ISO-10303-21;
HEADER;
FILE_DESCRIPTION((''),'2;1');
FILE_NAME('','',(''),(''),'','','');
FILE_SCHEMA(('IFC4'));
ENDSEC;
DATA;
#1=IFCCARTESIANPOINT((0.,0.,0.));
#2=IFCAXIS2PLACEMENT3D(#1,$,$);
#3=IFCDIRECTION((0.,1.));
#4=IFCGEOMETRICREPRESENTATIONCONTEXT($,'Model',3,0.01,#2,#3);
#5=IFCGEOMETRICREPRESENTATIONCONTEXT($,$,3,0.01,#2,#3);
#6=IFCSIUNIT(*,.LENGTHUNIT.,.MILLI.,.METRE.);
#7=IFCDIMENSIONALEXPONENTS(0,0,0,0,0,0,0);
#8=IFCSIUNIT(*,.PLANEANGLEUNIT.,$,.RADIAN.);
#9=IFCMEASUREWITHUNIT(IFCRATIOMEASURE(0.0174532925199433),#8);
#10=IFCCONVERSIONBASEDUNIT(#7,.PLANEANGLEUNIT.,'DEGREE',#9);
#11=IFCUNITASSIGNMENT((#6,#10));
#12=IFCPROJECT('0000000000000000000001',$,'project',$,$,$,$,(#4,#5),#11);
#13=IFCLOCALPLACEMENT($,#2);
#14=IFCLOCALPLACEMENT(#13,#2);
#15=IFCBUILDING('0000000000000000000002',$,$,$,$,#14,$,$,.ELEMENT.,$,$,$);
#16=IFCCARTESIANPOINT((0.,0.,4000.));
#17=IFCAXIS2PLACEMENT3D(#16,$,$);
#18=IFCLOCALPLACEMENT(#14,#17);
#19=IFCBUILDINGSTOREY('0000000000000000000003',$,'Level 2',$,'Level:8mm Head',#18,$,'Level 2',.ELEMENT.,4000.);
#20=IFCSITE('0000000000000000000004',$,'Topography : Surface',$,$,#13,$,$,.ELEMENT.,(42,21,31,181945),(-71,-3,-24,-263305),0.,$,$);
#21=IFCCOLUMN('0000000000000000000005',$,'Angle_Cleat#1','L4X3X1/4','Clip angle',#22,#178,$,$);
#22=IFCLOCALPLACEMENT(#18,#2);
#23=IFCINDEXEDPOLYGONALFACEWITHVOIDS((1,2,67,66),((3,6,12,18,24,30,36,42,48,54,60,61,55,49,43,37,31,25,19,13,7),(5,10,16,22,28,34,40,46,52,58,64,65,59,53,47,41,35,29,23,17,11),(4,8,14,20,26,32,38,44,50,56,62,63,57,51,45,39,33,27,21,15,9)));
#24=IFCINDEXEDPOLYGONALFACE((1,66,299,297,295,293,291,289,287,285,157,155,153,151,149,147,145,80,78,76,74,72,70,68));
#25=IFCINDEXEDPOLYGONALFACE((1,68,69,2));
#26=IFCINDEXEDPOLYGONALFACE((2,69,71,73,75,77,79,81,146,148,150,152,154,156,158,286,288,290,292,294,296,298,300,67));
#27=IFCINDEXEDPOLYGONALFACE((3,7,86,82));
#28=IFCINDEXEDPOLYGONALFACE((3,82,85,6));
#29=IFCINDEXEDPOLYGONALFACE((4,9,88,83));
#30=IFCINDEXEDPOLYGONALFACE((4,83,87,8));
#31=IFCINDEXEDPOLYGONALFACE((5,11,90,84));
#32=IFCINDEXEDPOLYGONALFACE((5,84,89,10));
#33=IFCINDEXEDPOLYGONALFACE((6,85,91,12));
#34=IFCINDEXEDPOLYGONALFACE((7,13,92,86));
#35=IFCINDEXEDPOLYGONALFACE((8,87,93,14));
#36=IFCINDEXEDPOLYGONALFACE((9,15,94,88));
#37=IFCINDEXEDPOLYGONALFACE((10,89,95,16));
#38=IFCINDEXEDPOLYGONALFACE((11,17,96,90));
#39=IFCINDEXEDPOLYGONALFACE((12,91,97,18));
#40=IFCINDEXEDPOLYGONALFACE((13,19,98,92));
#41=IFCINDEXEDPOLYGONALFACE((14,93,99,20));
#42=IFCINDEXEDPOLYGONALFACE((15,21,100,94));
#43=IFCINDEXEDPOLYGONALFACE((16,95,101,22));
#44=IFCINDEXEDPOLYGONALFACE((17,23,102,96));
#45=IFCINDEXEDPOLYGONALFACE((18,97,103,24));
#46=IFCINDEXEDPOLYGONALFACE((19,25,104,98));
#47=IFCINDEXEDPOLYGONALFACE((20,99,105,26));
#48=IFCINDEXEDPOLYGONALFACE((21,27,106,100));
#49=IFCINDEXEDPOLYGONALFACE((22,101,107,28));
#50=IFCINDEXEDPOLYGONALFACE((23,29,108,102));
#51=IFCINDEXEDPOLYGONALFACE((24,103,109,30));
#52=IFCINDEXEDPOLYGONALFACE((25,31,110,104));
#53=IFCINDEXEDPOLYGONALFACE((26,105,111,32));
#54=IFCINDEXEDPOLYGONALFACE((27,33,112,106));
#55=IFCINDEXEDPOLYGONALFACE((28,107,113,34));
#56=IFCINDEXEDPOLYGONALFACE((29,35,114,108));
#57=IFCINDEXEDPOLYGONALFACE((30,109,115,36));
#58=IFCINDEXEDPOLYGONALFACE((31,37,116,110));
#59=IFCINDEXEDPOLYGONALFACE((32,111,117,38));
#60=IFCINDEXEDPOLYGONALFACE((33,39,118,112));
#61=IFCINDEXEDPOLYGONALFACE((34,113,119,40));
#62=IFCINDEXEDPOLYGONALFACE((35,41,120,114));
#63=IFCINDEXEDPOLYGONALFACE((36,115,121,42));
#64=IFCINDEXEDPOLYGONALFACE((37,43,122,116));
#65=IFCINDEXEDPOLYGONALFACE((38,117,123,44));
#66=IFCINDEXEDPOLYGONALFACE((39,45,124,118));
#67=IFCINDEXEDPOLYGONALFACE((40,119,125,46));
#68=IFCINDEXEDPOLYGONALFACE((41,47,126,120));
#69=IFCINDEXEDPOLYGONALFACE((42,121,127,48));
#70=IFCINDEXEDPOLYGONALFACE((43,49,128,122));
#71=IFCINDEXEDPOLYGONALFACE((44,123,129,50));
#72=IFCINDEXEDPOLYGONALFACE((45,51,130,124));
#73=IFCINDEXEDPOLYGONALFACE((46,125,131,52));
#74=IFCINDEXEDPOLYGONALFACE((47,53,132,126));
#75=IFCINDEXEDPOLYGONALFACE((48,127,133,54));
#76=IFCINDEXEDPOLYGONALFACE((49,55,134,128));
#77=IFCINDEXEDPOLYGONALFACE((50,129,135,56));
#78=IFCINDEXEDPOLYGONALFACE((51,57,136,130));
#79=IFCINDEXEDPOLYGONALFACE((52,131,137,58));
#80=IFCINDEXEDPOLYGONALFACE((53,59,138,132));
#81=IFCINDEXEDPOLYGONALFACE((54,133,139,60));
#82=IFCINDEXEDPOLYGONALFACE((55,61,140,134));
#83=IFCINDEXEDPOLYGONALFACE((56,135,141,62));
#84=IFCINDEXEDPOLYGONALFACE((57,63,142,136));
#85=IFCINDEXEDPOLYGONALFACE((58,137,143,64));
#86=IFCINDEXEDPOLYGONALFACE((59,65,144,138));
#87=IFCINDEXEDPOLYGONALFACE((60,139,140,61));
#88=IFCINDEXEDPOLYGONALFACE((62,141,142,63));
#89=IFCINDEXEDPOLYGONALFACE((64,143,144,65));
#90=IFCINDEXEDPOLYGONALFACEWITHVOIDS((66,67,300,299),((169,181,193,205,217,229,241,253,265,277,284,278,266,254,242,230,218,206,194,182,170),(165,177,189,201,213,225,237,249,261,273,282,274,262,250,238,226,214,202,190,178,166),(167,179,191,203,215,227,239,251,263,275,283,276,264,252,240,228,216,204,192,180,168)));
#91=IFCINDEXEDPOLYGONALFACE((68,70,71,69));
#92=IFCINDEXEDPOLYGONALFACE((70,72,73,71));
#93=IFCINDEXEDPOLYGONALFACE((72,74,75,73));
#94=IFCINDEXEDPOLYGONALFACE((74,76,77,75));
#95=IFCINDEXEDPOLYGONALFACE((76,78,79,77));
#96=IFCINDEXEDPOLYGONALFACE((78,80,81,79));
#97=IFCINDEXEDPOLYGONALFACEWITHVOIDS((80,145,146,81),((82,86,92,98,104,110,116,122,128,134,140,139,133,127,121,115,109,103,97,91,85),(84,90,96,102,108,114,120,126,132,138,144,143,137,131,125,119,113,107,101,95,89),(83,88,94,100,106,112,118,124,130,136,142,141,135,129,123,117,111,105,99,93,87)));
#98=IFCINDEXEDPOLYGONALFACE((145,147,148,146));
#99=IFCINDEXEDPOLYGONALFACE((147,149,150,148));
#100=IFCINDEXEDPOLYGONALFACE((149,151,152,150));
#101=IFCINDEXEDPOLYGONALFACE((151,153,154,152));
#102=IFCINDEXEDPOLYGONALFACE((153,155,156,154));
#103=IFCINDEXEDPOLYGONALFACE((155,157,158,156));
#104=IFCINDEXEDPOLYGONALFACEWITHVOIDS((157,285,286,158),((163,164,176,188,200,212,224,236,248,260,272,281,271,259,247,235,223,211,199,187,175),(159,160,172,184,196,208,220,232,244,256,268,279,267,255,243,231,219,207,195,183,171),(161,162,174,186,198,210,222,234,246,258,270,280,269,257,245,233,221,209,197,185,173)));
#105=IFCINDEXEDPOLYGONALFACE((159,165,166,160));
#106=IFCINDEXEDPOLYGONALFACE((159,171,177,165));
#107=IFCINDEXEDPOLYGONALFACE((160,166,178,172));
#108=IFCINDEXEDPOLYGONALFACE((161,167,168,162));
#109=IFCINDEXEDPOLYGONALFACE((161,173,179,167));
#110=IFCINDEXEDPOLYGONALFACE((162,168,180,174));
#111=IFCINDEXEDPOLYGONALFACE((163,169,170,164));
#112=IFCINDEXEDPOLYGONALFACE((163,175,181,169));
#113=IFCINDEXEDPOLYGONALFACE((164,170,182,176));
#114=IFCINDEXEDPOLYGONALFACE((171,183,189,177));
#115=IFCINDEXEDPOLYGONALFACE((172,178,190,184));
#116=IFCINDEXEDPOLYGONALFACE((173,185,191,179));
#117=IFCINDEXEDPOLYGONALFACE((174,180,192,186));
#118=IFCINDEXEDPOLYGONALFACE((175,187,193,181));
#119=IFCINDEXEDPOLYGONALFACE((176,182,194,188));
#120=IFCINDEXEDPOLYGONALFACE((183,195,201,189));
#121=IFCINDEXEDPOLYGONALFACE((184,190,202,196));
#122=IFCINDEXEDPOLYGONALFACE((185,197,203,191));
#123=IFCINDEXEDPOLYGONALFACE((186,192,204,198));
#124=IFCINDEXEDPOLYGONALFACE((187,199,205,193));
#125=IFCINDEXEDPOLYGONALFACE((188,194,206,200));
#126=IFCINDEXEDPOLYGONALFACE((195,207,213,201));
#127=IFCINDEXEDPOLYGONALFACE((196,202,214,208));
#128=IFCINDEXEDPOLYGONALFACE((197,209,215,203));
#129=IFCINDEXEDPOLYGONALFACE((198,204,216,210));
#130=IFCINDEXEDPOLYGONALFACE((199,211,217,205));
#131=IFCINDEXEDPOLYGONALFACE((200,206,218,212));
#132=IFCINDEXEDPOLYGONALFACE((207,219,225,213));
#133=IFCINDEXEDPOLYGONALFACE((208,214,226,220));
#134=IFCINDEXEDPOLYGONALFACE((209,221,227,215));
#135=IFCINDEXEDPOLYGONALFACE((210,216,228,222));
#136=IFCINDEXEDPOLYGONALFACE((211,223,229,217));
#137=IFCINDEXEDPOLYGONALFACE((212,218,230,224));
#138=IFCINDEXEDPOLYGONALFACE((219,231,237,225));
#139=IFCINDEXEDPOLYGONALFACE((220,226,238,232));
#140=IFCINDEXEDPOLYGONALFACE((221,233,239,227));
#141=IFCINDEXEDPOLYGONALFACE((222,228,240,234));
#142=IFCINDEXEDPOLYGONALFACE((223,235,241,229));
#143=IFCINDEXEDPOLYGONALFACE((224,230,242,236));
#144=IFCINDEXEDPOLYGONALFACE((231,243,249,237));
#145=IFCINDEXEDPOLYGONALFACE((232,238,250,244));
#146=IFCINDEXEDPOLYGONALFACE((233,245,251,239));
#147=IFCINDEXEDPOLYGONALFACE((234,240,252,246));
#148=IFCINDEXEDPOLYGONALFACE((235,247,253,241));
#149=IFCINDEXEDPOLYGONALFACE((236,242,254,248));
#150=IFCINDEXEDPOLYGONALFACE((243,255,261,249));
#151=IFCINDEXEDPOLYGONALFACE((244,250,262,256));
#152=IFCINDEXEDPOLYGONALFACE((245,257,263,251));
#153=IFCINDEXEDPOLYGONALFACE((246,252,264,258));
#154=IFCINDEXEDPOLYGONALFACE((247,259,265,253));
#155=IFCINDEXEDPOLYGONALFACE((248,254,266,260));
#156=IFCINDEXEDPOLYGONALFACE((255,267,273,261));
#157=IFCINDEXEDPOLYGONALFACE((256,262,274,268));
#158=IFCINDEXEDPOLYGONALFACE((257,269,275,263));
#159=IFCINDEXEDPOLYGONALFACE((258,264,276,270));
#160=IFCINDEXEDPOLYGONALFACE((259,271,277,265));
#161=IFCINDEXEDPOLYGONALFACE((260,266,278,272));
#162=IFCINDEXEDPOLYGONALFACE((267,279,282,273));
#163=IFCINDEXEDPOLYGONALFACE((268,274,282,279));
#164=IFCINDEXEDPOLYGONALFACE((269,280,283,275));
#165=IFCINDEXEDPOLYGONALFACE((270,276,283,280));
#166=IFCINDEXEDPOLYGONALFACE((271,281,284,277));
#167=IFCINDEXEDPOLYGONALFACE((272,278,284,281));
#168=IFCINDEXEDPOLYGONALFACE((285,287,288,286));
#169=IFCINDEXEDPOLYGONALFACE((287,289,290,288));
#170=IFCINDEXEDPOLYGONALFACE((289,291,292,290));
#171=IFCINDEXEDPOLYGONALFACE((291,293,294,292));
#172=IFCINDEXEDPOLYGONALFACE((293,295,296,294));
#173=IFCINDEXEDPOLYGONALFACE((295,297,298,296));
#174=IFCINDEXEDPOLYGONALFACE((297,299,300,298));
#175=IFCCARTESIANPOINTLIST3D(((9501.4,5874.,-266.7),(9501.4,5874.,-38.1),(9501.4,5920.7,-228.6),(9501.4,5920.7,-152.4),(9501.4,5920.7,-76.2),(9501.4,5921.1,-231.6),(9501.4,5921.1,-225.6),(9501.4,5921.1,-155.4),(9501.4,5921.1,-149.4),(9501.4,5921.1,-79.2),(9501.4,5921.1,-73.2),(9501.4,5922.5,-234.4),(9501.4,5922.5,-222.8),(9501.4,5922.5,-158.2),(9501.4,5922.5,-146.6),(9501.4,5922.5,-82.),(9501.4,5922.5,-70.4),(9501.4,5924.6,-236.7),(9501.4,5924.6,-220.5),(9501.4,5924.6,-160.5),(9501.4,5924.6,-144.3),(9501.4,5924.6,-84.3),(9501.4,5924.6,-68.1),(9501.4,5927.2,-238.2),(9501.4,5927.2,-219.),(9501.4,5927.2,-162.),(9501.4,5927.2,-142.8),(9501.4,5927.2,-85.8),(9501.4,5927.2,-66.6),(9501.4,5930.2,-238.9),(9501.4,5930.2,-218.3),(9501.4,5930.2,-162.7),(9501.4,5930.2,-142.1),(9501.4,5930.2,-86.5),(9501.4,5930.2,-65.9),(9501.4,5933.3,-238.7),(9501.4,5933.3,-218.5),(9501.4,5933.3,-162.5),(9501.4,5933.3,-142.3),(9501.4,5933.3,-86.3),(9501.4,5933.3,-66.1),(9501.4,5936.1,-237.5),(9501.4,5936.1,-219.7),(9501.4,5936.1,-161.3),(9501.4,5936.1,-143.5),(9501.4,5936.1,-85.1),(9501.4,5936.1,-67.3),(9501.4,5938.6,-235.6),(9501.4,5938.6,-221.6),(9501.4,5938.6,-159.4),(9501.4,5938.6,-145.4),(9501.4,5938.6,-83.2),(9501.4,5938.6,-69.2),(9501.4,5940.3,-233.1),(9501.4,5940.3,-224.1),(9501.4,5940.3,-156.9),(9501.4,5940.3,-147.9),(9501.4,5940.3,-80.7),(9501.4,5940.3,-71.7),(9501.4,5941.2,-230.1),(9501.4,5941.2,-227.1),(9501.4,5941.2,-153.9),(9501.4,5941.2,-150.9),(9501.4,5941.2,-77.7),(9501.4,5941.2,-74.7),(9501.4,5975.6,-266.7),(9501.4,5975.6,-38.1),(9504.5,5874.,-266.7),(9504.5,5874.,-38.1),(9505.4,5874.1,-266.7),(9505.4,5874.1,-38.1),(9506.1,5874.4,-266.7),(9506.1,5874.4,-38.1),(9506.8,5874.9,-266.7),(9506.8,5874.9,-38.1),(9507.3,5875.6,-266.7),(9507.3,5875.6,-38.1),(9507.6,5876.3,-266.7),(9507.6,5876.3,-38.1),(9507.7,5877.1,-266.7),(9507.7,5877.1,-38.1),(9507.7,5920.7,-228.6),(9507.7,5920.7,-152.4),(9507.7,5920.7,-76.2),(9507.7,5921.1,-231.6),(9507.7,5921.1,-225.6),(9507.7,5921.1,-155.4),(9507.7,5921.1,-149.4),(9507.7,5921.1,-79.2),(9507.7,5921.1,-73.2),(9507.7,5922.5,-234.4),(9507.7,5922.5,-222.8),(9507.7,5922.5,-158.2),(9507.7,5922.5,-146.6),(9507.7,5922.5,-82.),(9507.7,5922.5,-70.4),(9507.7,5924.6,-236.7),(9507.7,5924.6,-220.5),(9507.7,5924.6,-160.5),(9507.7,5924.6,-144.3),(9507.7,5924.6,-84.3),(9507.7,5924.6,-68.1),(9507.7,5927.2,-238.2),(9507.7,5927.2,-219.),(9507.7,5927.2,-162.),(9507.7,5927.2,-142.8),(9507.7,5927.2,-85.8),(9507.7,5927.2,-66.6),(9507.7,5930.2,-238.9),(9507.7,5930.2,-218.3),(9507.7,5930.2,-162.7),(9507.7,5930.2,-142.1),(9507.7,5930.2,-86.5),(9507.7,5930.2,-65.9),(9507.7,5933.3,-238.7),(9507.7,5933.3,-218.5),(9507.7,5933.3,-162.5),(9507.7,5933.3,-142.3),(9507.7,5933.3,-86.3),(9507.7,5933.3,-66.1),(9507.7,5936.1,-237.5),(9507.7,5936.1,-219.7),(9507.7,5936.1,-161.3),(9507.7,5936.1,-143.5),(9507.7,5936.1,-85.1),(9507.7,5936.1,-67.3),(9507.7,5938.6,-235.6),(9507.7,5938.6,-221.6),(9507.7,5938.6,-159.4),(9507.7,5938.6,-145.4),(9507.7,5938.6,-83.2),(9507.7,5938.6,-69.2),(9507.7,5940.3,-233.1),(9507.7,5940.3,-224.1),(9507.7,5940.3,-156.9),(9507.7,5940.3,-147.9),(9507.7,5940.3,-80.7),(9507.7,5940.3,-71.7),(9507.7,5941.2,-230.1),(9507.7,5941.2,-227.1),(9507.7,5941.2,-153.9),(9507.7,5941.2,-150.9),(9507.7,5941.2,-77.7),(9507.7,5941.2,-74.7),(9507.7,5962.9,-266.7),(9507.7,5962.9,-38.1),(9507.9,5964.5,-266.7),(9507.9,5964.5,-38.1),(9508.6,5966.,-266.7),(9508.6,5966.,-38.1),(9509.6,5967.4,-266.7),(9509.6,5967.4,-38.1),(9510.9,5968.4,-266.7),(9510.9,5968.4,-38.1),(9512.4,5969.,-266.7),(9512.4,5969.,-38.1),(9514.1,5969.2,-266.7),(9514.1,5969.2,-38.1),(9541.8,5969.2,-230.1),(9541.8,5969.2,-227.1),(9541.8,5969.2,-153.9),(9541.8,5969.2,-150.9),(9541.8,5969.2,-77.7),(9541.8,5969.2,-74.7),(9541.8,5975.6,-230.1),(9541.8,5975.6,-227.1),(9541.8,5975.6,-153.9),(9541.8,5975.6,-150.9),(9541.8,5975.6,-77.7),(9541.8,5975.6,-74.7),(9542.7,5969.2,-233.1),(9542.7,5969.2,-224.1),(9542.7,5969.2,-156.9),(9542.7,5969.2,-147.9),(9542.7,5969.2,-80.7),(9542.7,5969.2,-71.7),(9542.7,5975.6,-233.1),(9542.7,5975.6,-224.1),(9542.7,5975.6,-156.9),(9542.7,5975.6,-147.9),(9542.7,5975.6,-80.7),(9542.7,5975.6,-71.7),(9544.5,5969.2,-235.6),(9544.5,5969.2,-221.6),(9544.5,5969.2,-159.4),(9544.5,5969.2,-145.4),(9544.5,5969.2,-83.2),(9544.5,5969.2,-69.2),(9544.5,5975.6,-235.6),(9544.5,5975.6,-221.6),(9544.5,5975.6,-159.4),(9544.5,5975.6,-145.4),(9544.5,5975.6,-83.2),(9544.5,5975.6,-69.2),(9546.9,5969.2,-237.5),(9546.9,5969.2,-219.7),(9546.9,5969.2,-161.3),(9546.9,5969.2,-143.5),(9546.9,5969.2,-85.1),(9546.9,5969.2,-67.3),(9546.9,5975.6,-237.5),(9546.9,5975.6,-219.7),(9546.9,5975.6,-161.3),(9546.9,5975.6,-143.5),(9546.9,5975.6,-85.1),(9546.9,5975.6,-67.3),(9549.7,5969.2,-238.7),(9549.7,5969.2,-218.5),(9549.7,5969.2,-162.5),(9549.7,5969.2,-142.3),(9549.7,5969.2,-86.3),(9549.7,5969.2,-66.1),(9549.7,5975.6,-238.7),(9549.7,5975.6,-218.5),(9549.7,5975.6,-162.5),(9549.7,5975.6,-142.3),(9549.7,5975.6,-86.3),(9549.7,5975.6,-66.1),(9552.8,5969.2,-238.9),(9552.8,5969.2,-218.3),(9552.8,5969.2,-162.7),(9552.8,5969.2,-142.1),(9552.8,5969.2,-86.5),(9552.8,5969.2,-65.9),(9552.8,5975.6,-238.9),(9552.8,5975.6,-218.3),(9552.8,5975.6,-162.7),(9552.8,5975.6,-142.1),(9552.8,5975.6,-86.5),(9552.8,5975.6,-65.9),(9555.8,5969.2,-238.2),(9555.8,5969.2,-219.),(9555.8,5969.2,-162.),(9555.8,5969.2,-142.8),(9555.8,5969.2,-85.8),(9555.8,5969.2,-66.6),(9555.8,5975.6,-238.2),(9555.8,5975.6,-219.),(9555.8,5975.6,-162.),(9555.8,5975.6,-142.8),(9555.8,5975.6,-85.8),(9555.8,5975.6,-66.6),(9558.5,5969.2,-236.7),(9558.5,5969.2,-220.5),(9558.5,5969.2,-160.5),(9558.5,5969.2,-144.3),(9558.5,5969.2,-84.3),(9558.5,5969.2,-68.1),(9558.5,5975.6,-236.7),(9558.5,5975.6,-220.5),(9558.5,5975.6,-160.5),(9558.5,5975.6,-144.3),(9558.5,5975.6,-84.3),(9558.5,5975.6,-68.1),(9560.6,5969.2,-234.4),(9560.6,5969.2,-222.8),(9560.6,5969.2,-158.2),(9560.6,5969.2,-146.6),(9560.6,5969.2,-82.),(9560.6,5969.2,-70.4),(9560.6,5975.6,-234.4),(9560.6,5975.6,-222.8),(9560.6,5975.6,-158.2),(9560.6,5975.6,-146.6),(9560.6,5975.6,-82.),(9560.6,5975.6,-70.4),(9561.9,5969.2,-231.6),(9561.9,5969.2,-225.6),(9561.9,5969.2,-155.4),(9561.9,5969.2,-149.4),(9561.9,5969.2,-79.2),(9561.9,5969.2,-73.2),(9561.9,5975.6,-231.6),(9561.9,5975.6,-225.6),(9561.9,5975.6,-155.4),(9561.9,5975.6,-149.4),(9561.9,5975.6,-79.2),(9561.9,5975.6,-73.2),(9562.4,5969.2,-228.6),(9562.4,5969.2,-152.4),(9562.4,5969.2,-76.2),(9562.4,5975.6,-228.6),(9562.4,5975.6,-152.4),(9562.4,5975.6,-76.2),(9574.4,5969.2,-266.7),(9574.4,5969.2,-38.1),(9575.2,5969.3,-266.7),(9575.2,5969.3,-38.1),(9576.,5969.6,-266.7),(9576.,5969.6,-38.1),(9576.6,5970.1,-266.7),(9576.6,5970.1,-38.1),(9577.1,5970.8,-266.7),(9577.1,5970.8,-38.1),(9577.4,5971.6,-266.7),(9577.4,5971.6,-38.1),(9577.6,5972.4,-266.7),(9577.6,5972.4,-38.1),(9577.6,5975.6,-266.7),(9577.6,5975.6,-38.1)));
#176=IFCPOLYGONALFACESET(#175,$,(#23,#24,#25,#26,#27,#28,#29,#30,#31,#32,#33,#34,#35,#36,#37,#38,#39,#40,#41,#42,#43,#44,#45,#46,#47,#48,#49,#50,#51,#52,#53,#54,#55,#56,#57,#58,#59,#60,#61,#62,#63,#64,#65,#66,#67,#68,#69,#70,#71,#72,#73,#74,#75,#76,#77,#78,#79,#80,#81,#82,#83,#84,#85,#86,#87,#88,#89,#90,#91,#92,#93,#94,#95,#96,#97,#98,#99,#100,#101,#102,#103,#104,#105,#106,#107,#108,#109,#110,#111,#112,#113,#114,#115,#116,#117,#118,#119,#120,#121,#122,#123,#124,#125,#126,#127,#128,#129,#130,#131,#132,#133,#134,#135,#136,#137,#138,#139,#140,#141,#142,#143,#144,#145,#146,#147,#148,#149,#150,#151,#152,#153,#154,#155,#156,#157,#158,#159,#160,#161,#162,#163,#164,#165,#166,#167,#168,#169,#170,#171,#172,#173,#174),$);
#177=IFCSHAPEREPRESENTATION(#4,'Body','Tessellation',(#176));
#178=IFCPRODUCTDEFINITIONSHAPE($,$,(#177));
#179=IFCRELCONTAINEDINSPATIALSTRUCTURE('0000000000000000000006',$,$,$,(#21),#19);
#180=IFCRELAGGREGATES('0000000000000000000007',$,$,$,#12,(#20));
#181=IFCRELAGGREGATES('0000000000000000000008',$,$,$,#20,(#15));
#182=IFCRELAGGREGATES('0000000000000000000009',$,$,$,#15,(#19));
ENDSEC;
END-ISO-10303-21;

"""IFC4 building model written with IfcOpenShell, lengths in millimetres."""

from ifc_helpers import new_model, entity, si_unit, converted_unit, direction, frame, frame_2d, origin, origin_2d_with_axis, place, context, project, spatial, circle, l_section, extrude, element, save


model = new_model("IFC4")

# Units and contexts
model_context = context("Model", 3, precision=0.01, world=origin(), true_north=direction((0.0, 1.0)))
context_of_model = context(None, 3, precision=0.01, world=origin(), true_north=direction((0.0, 1.0)))
ifc_project = project(units=[si_unit("LENGTHUNIT", "METRE", prefix="MILLI"), converted_unit("PLANEANGLEUNIT", "DEGREE", entity("IfcRatioMeasure", 0.0174532925199433), si_unit("PLANEANGLEUNIT", "RADIAN"), dimensions=[0, 0, 0, 0, 0, 0, 0])], contexts=[model_context, context_of_model])

# Site, building, storey
site_placement = place(None, origin())
site = spatial("IfcSite", under=ifc_project, at=site_placement, Name="Topography : Surface", CompositionType="ELEMENT", RefLatitude=(42, 21, 31, 181945), RefLongitude=(-71, -3, -24, -263305), RefElevation=0.0)
building_placement = place(site_placement, origin())
building = spatial("IfcBuilding", under=site, at=building_placement, CompositionType="ELEMENT")
storey_placement = place(building_placement, frame((0.0, 0.0, 4000.0)))
storey = spatial("IfcBuildingStorey", under=building, at=storey_placement, Name="Level 2", ObjectType="Level:8mm Head", LongName="Level 2", CompositionType="ELEMENT", Elevation=4000.0)

# Column, openings
column_1_placement = place(storey_placement, frame((9519.6, 5944.4, -266.7), z_axis=(0.0, 0.0, -1.0), x_axis=(1.0, 0.0, 0.0)))
column_1 = element("IfcColumn", 1, at=column_1_placement, inside=storey, Name="Angle_Cleat#1", Description="L4X3X1/4", ObjectType="Clip angle", context=model_context, shape_type="SweptSolid", body=[
    extrude(l_section(Depth=101.6, Width=76.2, Thickness=6.3, FilletRadius=6.3, EdgeRadius=3.2, at=frame_2d((19.8, 19.7))), origin(), (0.0, 0.0, -1.0), 228.6),
])
opening_1_placement = place(column_1_placement, frame((-18.9, 13.5, -114.3), z_axis=(1.0, 0.0, 0.0), x_axis=(0.0, 1.0, 0.0)))
element("IfcOpeningElement", 2, at=opening_1_placement, cuts=column_1, ObjectType="Opening", context=model_context, shape_type="SweptSolid", body=[
    extrude(circle(Radius=10.3, at=origin_2d_with_axis()), origin(), (0.0, 0.0, 1.0), 7.3),
])
opening_2_placement = place(column_1_placement, frame((-18.9, 13.5, -114.3), z_axis=(1.0, 0.0, 0.0), x_axis=(0.0, 1.0, 0.0)))
element("IfcOpeningElement", 3, at=opening_2_placement, cuts=column_1, ObjectType="Opening", context=model_context, shape_type="SweptSolid", body=[
    extrude(circle(Radius=10.3, at=frame_2d((0.0, 76.2), x_axis=(1.0, 0.0))), origin(), (0.0, 0.0, 1.0), 7.3),
])
opening_3_placement = place(column_1_placement, frame((-18.9, 13.5, -114.3), z_axis=(1.0, 0.0, 0.0), x_axis=(0.0, 1.0, 0.0)))
element("IfcOpeningElement", 4, at=opening_3_placement, cuts=column_1, ObjectType="Opening", context=model_context, shape_type="SweptSolid", body=[
    extrude(circle(Radius=10.3, at=frame_2d((0.0, -76.2), x_axis=(1.0, 0.0))), origin(), (0.0, 0.0, 1.0), 7.3),
])
opening_4_placement = place(column_1_placement, frame((32.4, -31.5, -114.3), z_axis=(0.0, 1.0, 0.0), x_axis=(1.0, 0.0, 0.0)))
element("IfcOpeningElement", 5, at=opening_4_placement, cuts=column_1, ObjectType="Opening", context=model_context, shape_type="SweptSolid", body=[
    extrude(circle(Radius=10.3, at=origin_2d_with_axis()), origin(), (0.0, 0.0, 1.0), 7.3),
])
opening_5_placement = place(column_1_placement, frame((32.4, -31.5, -114.3), z_axis=(0.0, 1.0, 0.0), x_axis=(1.0, 0.0, 0.0)))
element("IfcOpeningElement", 6, at=opening_5_placement, cuts=column_1, ObjectType="Opening", context=model_context, shape_type="SweptSolid", body=[
    extrude(circle(Radius=10.3, at=frame_2d((0.0, 76.2), x_axis=(1.0, 0.0))), origin(), (0.0, 0.0, 1.0), 7.3),
])
opening_6_placement = place(column_1_placement, frame((32.4, -31.5, -114.3), z_axis=(0.0, 1.0, 0.0), x_axis=(1.0, 0.0, 0.0)))
element("IfcOpeningElement", 7, at=opening_6_placement, cuts=column_1, ObjectType="Opening", context=model_context, shape_type="SweptSolid", body=[
    extrude(circle(Radius=10.3, at=frame_2d((0.0, -76.2), x_axis=(1.0, 0.0))), origin(), (0.0, 0.0, 1.0), 7.3),
])

save(model, "model.ifc")
